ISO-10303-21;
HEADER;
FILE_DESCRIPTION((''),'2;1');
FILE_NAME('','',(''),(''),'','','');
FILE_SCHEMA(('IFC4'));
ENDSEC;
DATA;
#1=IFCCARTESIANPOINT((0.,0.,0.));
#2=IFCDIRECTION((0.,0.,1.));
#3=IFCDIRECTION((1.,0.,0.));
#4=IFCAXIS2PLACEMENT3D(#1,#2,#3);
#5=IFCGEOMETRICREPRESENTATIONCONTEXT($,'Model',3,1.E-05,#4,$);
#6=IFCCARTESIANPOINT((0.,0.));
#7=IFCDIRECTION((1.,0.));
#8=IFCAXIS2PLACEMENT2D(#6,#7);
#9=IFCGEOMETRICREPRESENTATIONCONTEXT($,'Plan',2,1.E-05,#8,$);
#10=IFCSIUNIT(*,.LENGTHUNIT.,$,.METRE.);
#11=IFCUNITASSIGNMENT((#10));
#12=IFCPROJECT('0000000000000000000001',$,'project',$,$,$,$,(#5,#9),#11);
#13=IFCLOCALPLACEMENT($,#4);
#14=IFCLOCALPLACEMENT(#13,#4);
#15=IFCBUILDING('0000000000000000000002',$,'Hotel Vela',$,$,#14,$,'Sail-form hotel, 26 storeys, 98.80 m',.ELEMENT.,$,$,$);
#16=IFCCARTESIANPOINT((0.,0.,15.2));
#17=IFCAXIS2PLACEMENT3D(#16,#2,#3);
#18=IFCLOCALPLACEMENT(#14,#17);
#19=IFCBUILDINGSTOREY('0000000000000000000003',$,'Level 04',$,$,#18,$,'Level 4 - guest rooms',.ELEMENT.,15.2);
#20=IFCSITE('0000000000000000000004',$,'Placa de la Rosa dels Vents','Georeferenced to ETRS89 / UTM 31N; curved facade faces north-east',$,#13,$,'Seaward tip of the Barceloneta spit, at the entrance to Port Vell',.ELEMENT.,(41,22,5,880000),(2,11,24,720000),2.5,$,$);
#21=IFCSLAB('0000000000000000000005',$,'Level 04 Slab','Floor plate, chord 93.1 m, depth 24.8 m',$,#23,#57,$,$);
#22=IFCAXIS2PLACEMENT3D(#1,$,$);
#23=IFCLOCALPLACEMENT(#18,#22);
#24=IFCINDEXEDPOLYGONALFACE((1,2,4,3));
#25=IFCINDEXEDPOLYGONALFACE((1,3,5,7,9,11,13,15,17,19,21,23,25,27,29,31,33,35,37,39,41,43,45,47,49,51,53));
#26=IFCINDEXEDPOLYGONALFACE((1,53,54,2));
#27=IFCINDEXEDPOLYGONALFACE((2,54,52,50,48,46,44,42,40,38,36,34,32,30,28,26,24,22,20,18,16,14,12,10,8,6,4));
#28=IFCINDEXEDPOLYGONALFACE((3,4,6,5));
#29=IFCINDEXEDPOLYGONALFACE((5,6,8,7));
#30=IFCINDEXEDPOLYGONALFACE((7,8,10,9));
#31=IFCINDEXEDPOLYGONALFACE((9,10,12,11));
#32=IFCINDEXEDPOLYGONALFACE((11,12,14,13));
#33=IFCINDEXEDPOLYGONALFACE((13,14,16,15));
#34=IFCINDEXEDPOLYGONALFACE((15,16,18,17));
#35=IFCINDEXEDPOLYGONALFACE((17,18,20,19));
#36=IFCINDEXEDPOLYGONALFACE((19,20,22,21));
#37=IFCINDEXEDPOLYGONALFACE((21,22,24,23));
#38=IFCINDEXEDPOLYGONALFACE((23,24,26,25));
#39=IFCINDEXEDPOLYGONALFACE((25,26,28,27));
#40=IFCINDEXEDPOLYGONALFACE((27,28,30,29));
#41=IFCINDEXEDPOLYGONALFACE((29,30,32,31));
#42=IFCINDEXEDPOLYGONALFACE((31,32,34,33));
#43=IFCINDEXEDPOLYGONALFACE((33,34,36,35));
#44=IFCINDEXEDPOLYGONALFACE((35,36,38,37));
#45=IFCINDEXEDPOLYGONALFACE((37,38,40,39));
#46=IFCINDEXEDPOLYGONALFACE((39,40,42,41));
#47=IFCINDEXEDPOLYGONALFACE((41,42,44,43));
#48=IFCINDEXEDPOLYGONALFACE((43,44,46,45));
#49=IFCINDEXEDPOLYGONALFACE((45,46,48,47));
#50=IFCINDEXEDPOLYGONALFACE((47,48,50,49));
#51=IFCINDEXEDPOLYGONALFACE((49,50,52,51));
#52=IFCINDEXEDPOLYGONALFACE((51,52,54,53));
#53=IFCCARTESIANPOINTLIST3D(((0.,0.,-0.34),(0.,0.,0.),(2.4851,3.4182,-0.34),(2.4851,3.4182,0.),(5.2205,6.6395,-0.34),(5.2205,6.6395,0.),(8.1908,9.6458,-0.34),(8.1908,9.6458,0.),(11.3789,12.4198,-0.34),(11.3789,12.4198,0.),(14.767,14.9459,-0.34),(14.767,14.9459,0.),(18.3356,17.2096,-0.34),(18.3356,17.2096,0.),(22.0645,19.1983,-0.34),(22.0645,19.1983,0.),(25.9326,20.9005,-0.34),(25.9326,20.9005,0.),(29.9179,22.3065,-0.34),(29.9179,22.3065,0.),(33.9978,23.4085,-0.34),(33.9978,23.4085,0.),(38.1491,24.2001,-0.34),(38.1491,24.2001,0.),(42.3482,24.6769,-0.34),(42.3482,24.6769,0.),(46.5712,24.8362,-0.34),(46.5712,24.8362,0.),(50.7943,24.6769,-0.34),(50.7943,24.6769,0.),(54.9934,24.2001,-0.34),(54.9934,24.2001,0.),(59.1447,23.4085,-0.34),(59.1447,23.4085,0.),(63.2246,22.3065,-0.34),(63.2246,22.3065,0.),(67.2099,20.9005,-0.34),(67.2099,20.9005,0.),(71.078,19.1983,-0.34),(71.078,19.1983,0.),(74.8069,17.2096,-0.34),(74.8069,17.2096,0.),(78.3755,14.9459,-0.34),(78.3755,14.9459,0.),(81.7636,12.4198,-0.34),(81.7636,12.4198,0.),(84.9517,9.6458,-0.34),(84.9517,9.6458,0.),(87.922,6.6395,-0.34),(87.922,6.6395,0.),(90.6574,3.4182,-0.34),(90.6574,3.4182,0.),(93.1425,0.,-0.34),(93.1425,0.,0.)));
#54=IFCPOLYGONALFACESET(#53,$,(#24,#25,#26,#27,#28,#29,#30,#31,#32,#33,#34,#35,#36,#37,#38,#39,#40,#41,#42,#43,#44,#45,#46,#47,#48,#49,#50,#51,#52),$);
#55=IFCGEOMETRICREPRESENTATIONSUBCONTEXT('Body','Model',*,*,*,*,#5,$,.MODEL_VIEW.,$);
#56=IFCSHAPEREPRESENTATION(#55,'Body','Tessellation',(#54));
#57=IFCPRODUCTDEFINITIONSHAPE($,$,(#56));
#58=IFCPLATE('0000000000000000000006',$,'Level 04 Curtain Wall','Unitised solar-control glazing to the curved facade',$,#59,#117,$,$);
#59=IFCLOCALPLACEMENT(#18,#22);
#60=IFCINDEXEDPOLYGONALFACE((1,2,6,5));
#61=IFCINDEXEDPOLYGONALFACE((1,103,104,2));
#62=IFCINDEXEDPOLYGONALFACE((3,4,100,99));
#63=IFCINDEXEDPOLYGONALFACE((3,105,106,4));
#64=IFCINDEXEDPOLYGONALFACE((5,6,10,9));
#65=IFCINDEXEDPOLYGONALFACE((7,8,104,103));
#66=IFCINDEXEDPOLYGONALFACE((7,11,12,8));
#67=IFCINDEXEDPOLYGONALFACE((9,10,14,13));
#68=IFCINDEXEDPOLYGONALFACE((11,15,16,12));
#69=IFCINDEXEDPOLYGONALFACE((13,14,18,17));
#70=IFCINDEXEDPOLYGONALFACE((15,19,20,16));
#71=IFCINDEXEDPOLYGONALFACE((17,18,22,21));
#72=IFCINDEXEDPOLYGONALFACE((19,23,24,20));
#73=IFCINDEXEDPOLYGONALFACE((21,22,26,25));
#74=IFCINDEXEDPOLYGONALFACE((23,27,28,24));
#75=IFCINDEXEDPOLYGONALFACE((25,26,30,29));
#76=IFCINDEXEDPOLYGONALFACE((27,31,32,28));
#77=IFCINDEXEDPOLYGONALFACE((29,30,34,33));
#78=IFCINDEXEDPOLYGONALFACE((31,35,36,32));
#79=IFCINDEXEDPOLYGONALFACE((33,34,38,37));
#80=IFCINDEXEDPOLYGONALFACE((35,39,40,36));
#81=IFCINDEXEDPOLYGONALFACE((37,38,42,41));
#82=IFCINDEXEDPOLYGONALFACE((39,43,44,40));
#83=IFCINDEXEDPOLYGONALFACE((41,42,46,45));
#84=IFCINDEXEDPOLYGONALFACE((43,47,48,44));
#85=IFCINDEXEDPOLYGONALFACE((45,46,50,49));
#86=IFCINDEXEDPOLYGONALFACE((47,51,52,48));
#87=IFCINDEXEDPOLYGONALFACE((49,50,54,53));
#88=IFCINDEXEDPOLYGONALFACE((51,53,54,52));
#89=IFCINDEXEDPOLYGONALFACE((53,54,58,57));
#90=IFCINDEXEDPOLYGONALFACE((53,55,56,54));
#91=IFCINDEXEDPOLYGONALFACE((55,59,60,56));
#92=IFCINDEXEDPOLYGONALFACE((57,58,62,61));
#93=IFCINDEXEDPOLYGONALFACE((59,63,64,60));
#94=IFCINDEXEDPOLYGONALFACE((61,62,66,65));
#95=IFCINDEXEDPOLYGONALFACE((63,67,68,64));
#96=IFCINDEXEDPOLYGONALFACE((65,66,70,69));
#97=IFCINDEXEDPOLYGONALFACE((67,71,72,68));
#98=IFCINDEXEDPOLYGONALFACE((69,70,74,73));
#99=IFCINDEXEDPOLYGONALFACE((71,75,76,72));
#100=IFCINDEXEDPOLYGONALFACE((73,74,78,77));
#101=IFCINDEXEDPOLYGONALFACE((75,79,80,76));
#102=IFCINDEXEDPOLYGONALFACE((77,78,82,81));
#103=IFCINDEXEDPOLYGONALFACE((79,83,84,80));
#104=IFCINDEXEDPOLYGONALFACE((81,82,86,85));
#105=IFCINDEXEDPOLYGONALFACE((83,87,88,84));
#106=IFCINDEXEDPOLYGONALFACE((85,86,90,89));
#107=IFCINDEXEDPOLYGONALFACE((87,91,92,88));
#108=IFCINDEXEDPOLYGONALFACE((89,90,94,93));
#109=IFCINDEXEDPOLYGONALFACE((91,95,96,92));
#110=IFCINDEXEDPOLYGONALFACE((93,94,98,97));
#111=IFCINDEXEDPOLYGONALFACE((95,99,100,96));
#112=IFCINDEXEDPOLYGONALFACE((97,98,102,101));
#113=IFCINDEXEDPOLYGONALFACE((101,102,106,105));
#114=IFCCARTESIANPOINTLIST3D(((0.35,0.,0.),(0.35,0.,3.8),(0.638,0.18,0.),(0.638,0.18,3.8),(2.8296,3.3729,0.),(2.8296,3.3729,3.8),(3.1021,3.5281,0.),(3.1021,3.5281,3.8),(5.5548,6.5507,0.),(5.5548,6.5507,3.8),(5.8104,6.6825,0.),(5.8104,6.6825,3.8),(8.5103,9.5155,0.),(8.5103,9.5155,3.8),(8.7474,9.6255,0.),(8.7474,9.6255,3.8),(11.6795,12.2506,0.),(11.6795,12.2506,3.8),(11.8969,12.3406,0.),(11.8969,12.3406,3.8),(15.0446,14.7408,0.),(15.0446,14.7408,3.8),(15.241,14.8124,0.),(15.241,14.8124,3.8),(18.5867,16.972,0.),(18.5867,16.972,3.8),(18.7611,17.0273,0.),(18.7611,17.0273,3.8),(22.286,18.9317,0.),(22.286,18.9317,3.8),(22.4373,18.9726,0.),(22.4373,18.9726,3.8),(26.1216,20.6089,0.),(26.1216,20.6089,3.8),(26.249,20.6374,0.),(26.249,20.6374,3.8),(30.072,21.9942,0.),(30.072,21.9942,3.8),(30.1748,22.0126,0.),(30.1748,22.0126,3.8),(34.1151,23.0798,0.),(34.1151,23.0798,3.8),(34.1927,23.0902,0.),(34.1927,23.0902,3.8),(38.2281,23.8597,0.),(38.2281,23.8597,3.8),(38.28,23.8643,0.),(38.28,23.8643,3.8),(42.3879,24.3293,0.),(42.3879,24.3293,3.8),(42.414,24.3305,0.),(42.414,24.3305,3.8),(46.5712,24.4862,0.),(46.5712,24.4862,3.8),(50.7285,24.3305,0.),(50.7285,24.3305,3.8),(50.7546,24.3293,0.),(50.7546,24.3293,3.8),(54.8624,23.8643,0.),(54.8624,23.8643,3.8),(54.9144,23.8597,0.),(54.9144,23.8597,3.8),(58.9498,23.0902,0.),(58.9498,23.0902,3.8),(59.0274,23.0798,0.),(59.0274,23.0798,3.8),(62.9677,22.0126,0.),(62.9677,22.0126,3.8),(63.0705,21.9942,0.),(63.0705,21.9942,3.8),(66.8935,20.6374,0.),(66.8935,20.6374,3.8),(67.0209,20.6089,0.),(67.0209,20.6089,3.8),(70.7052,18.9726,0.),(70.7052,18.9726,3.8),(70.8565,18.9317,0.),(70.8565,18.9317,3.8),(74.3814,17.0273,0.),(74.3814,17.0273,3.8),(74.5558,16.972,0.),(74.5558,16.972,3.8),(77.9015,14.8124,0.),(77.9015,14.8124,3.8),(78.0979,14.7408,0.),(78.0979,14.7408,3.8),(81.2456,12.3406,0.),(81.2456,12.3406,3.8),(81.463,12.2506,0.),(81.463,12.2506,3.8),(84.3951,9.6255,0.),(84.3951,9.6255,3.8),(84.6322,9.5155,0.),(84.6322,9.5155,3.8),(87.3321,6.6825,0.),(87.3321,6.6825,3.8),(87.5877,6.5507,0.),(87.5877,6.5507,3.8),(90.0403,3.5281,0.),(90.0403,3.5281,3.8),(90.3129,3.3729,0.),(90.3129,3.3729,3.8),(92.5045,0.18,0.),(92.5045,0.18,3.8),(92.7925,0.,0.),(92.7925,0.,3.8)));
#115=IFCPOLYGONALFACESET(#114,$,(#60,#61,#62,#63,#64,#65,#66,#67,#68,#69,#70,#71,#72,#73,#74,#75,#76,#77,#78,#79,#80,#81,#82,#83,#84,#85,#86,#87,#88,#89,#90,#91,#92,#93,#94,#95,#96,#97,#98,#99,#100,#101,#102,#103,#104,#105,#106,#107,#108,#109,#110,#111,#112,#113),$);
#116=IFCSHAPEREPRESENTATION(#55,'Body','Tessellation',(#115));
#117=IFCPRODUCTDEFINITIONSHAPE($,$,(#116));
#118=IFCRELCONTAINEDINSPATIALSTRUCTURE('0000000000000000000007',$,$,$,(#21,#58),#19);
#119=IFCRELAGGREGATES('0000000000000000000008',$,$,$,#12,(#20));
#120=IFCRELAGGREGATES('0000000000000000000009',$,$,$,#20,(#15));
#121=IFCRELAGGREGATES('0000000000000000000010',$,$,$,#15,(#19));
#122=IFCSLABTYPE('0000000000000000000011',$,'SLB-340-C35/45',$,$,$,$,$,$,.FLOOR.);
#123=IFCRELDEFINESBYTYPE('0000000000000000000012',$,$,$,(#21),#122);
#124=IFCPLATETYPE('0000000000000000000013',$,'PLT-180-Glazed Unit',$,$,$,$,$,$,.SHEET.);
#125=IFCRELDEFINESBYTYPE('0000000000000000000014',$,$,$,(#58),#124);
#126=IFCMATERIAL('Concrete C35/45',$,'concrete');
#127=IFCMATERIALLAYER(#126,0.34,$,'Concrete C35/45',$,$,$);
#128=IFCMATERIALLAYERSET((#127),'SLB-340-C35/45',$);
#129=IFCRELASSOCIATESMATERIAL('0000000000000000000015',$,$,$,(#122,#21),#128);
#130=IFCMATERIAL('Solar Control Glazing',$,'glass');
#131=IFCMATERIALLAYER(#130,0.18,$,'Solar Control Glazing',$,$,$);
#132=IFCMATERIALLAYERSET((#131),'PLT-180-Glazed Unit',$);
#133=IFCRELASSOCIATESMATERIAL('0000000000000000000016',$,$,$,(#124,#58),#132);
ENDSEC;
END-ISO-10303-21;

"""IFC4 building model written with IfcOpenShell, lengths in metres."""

from ifc_helpers import new_model, si_unit, frame, origin_with_axes, origin_2d_with_axis, place, context, subcontext, project, spatial, line, indexed_curve, outline, extrude, material, layer, layer_set, layer_usage, type_object, element, save


model = new_model("IFC4")

# Units and contexts
model_context = context("Model", 3, precision=1e-05, world=origin_with_axes())
plan_context = context("Plan", 2, precision=1e-05, world=origin_2d_with_axis())
body_context = subcontext(model_context, "Body", "Model", "MODEL_VIEW")
ifc_project = project(units=[si_unit("LENGTHUNIT", "METRE")], contexts=[model_context, plan_context])

# Site, building, storey
site_placement = place(None, origin_with_axes())
site = spatial("IfcSite", under=ifc_project, at=site_placement, Name="Placa de la Rosa dels Vents", Description="Georeferenced to ETRS89 / UTM 31N; curved facade faces north-east", LongName="Seaward tip of the Barceloneta spit, at the entrance to Port Vell", CompositionType="ELEMENT", RefLatitude=(41, 22, 5, 880000), RefLongitude=(2, 11, 24, 720000), RefElevation=2.5)
building_placement = place(site_placement, origin_with_axes())
building = spatial("IfcBuilding", under=site, at=building_placement, Name="Hotel Vela", LongName="Sail-form hotel, 26 storeys, 98.80 m", CompositionType="ELEMENT")
storey_placement = place(building_placement, frame((0.0, 0.0, 15.2), z_axis=(0.0, 0.0, 1.0), x_axis=(1.0, 0.0, 0.0)))
storey = spatial("IfcBuildingStorey", under=building, at=storey_placement, Name="Level 04", LongName="Level 4 - guest rooms", CompositionType="ELEMENT", Elevation=15.2)

# Slab
ifc_material_1 = material(Name="Concrete C35/45", Category="concrete")
ifc_layer_1 = layer(ifc_material_1, 0.34, Name="Concrete C35/45")
ifc_layer_set_1 = layer_set([ifc_layer_1], Name="SLB-340-C35/45")
ifc_layer_usage_1 = layer_usage(ifc_layer_set_1, "AXIS3", "POSITIVE", 0.0)
slab_type = type_object("IfcSlabType", Name="SLB-340-C35/45", PredefinedType="FLOOR", material=ifc_layer_set_1)
slab_placement = place(storey_placement, frame((0.0, 0.0, -0.34), z_axis=(0.0, 0.0, 1.0), x_axis=(1.0, 0.0, 0.0)))
element("IfcSlab", 1, at=slab_placement, inside=storey, type_object=slab_type, material=ifc_layer_usage_1, Name="Level 04 Slab", Description="Floor plate, chord 93.1 m, depth 24.8 m", context=body_context, shape_type="SweptSolid", body=[
    extrude(outline(indexed_curve([(0.0, 0.0), (93.1425, 0.0), (90.6574, 3.4182), (87.922, 6.6395), (84.9517, 9.6458), (81.7636, 12.4198), (78.3755, 14.9459), (74.8069, 17.2096), (71.078, 19.1983), (67.2099, 20.9005), (63.2246, 22.3065), (59.1447, 23.4085), (54.9934, 24.2001), (50.7943, 24.6769), (46.5712, 24.8362), (42.3482, 24.6769), (38.1491, 24.2001), (33.9978, 23.4085), (29.9179, 22.3065), (25.9326, 20.9005), (22.0645, 19.1983), (18.3356, 17.2096), (14.767, 14.9459), (11.3789, 12.4198), (8.1908, 9.6458), (5.2205, 6.6395), (2.4851, 3.4182)], segments=[line(1, 2, 3, 4, 5, 6, 7, 8, 9, 10, 11, 12, 13, 14, 15, 16, 17, 18, 19, 20, 21, 22, 23, 24, 25, 26, 27, 1)])), origin_with_axes(), (0.0, 0.0, 1.0), 0.34),
])

# Plate
ifc_material_2 = material(Name="Solar Control Glazing", Category="glass")
ifc_layer_2 = layer(ifc_material_2, 0.18, Name="Solar Control Glazing")
ifc_layer_set_2 = layer_set([ifc_layer_2], Name="PLT-180-Glazed Unit")
ifc_layer_usage_2 = layer_usage(ifc_layer_set_2, "AXIS2", "POSITIVE", 0.0)
plate_type_1 = type_object("IfcPlateType", Name="PLT-180-Glazed Unit", PredefinedType="SHEET", material=ifc_layer_set_2)
plate_1_placement = place(storey_placement, frame((0.35, 0.0, 0.0), z_axis=(0.0, 0.0, 1.0), x_axis=(1.0, 0.0, 0.0)))
element("IfcPlate", 2, at=plate_1_placement, inside=storey, type_object=plate_type_1, material=ifc_layer_usage_2, Name="Level 04 Curtain Wall", Description="Unitised solar-control glazing to the curved facade", context=body_context, shape_type="SweptSolid", body=[
    extrude(outline(indexed_curve([(92.4425, 0.0), (89.9629, 3.3729), (87.2377, 6.5507), (84.2822, 9.5155), (81.113, 12.2506), (77.7479, 14.7408), (74.2058, 16.972), (70.5065, 18.9317), (66.6709, 20.6089), (62.7205, 21.9942), (58.6774, 23.0798), (54.5644, 23.8597), (50.4046, 24.3293), (46.2212, 24.4862), (42.0379, 24.3293), (37.8781, 23.8597), (33.7651, 23.0798), (29.722, 21.9942), (25.7716, 20.6089), (21.936, 18.9317), (18.2367, 16.972), (14.6946, 14.7408), (11.3295, 12.2506), (8.1603, 9.5155), (5.2048, 6.5507), (2.4796, 3.3729), (0.0, 0.0), (92.1545, 0.18), (2.7521, 3.5281), (5.4604, 6.6825), (8.3974, 9.6255), (11.5469, 12.3406), (14.891, 14.8124), (18.4111, 17.0273), (22.0873, 18.9726), (25.899, 20.6374), (29.8248, 22.0126), (33.8427, 23.0902), (37.93, 23.8643), (42.064, 24.3305), (46.2212, 24.4862), (50.3785, 24.3305), (54.5124, 23.8643), (58.5998, 23.0902), (62.6177, 22.0126), (66.5435, 20.6374), (70.3552, 18.9726), (74.0314, 17.0273), (77.5515, 14.8124), (80.8956, 12.3406), (84.0451, 9.6255), (86.9821, 6.6825), (89.6903, 3.5281), (0.288, 0.18)], segments=[line(1, 2, 3, 4, 5, 6, 7, 8, 9, 10, 11, 12, 13, 14, 15, 16, 17, 18, 19, 20, 21, 22, 23, 24, 25, 26, 27, 28, 29, 30, 31, 32, 33, 34, 35, 36, 37, 38, 39, 40, 41, 42, 43, 44, 45, 46, 47, 48, 49, 50, 51, 52, 53, 54, 1)])), origin_with_axes(), (0.0, 0.0, 1.0), 3.8),
])

save(model, "model.ifc")
